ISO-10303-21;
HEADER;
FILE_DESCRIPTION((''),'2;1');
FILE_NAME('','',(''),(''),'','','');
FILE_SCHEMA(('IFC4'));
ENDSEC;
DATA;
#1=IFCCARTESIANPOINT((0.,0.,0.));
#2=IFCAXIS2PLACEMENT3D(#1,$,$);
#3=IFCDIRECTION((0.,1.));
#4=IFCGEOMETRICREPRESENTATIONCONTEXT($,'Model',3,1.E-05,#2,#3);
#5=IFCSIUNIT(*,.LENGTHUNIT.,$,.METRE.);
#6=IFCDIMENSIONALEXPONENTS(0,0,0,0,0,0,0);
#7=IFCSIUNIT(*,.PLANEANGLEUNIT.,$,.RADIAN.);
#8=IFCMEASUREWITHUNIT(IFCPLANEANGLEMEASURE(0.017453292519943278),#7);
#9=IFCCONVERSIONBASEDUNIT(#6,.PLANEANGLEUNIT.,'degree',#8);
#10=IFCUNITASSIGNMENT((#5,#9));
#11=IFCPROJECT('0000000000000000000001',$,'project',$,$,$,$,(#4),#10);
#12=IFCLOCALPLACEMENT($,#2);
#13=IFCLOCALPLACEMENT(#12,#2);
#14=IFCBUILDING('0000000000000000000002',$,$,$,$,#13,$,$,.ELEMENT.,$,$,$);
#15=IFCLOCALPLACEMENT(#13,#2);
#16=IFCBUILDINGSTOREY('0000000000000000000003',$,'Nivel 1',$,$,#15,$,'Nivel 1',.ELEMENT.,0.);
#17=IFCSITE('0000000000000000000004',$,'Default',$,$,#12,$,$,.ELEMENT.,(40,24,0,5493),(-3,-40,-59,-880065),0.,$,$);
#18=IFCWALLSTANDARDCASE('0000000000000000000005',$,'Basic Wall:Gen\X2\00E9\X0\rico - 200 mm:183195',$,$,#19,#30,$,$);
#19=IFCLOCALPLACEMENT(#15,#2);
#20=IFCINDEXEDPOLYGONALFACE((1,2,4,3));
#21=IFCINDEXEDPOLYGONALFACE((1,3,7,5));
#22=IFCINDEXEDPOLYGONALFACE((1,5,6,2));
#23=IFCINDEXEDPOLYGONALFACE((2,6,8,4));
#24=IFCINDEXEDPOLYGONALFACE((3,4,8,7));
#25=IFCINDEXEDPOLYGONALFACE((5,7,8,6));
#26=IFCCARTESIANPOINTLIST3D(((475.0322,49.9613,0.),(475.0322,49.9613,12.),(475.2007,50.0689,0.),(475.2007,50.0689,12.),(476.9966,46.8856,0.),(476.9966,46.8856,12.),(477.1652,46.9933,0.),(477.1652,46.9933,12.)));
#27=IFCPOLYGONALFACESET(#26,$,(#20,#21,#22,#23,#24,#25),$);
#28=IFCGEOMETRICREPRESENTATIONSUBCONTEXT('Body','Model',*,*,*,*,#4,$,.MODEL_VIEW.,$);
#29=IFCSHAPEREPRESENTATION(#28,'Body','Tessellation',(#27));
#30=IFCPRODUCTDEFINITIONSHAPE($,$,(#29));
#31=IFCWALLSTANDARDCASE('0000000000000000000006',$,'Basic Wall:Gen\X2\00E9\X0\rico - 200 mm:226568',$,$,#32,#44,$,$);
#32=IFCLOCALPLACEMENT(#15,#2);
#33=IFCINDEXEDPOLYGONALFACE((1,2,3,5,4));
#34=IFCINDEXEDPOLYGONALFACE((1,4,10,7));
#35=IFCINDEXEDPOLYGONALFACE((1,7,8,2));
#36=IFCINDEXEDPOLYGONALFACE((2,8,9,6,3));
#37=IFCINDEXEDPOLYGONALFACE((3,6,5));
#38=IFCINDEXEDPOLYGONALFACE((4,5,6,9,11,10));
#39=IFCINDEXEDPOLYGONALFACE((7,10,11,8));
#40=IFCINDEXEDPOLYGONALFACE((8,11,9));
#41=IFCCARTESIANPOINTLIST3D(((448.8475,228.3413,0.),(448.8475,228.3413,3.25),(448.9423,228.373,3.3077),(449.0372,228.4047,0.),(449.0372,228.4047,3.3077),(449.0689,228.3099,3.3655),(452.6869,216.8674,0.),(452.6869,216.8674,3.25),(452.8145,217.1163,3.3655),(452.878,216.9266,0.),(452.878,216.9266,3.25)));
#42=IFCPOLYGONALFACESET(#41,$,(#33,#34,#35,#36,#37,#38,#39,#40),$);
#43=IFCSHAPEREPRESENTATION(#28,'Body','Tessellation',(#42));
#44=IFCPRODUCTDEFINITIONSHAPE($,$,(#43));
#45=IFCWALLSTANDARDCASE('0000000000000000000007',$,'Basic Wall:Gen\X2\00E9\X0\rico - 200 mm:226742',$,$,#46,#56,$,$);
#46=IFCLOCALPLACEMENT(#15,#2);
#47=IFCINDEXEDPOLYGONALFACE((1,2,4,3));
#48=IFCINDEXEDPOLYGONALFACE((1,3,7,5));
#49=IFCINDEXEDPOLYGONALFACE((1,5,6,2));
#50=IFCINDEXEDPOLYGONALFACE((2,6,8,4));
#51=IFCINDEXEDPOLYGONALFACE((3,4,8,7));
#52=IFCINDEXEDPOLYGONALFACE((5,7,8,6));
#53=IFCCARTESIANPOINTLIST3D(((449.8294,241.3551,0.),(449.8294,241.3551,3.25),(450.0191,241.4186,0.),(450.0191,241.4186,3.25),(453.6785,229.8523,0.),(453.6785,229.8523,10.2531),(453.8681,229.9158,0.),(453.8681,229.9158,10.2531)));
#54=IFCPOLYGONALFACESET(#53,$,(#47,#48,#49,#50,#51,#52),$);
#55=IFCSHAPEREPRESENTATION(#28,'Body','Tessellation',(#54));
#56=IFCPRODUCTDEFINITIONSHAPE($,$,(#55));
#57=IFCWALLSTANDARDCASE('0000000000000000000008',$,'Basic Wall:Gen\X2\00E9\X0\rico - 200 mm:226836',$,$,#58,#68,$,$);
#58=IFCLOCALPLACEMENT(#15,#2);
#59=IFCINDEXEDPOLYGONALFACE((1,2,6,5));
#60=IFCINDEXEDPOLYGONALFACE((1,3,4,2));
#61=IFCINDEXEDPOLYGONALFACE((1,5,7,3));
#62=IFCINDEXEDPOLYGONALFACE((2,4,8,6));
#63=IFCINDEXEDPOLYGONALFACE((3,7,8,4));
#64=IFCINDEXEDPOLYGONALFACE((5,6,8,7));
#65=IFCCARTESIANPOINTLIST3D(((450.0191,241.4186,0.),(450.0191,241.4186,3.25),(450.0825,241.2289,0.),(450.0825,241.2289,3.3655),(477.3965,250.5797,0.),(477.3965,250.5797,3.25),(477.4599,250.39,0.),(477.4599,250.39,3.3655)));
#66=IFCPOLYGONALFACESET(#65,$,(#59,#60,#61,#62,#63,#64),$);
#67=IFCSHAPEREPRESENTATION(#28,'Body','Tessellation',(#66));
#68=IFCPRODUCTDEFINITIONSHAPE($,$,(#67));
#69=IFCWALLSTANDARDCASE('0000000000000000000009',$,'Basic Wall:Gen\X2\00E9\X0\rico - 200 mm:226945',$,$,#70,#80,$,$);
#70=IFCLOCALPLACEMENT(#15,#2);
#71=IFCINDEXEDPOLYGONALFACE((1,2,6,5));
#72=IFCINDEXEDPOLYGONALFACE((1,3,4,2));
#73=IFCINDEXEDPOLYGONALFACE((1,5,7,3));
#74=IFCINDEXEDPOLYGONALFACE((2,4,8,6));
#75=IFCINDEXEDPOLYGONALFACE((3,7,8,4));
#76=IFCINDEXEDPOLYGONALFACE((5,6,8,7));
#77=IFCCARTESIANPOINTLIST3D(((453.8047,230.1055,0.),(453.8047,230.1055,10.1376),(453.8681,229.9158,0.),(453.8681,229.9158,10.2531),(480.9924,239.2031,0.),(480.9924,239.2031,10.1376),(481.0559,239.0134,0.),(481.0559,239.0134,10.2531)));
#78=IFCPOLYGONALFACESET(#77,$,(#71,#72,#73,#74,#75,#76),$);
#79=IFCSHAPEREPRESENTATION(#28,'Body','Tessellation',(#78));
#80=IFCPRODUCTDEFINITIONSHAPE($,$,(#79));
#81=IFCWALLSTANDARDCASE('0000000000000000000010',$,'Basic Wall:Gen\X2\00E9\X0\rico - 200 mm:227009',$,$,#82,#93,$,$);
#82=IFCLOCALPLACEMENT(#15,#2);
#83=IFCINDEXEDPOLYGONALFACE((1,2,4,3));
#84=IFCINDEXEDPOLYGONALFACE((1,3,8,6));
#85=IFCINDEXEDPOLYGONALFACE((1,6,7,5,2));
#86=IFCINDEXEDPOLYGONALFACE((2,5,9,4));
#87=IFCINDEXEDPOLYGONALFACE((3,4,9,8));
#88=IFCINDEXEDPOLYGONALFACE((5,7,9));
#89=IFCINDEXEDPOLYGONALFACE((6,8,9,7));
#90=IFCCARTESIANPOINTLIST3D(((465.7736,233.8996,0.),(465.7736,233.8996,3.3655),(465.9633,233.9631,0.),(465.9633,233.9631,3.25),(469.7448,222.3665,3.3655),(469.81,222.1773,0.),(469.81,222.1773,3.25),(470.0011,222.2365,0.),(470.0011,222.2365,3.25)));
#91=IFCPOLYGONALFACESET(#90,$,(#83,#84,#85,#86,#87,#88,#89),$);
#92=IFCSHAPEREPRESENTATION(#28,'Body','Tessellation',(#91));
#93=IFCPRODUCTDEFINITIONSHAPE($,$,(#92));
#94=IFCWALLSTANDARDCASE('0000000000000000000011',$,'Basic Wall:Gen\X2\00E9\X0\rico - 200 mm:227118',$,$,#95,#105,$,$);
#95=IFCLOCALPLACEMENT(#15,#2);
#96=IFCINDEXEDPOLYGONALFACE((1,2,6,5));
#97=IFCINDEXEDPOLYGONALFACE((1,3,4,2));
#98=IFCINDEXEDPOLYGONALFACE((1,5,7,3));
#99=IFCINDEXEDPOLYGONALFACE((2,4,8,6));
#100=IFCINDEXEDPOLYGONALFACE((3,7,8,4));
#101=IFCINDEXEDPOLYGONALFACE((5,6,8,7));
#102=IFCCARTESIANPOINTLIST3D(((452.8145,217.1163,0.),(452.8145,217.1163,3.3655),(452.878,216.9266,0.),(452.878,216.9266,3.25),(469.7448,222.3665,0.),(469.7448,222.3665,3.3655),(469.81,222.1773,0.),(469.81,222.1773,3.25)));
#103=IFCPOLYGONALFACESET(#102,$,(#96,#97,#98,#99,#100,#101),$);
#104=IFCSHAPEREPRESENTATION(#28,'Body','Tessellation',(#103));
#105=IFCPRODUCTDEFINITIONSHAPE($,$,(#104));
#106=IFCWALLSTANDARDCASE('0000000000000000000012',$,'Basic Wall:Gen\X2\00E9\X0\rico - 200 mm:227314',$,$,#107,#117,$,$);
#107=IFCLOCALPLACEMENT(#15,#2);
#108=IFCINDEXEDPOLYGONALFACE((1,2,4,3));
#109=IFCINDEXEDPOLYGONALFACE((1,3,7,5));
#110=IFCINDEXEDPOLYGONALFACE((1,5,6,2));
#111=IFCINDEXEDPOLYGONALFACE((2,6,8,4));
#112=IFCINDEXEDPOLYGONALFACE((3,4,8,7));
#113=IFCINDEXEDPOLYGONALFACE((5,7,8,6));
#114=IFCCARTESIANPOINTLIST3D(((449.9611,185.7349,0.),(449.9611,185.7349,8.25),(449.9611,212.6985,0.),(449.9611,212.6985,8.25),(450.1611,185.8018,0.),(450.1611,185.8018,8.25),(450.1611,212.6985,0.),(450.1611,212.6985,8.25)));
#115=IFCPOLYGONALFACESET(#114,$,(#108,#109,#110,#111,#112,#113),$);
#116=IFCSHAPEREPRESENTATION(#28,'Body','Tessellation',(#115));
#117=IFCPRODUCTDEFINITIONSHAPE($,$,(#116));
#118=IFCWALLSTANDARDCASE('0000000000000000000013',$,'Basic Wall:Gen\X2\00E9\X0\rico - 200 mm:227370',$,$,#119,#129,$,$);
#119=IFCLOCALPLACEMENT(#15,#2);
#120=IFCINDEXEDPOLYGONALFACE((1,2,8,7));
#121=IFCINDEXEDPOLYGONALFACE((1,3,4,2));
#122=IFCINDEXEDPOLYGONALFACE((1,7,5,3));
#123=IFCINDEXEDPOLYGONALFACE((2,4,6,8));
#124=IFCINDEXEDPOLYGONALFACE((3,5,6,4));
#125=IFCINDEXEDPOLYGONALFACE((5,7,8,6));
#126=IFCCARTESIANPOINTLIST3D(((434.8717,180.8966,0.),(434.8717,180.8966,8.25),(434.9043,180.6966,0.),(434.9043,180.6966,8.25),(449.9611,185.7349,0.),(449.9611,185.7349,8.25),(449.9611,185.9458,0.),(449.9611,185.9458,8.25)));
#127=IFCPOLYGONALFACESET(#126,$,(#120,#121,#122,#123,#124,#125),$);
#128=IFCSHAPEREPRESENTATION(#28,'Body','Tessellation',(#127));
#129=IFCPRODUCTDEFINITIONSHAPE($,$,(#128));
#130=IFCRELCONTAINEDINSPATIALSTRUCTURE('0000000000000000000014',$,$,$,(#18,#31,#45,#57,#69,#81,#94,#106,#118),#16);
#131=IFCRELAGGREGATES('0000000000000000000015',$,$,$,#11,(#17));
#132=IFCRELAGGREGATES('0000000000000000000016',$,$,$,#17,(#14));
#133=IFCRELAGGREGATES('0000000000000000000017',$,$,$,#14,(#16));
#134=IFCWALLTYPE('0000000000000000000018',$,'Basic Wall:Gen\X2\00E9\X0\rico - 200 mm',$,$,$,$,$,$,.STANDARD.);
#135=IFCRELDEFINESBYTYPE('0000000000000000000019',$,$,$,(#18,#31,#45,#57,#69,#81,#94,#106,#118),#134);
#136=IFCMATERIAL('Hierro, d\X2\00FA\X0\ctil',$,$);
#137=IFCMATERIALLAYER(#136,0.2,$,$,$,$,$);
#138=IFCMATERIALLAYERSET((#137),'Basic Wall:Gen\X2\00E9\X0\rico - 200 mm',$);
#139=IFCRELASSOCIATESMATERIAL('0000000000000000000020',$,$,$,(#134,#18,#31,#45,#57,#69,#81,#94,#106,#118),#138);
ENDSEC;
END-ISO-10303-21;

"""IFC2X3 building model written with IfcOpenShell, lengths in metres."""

from ifc_helpers import new_model, entity, si_unit, converted_unit, direction, frame, frame_2d, origin, place, context, subcontext, project, spatial, polyline, rectangle, outline, extrude, clip, bounded_halfspace, material, layer, layer_set, layer_usage, type_object, element, save


model = new_model("IFC2X3")

# Units and contexts
model_context = context("Model", 3, precision=1e-05, world=origin(), true_north=direction((0.0, 1.0)))
body_context = subcontext(model_context, "Body", "Model", "MODEL_VIEW")
ifc_project = project(units=[si_unit("LENGTHUNIT", "METRE"), converted_unit("PLANEANGLEUNIT", "degree", entity("IfcPlaneAngleMeasure", 0.017453292519943278), si_unit("PLANEANGLEUNIT", "RADIAN"), dimensions=[0, 0, 0, 0, 0, 0, 0])], contexts=[model_context])

# Site, building, storey
site_placement = place(None, origin())
site = spatial("IfcSite", under=ifc_project, at=site_placement, Name="Default", CompositionType="ELEMENT", RefLatitude=(40, 24, 0, 5493), RefLongitude=(-3, -40, -59, -880065), RefElevation=0.0)
building_placement = place(site_placement, origin())
building = spatial("IfcBuilding", under=site, at=building_placement, CompositionType="ELEMENT")
storey_placement = place(building_placement, origin())
storey = spatial("IfcBuildingStorey", under=building, at=storey_placement, Name="Nivel 1", LongName="Nivel 1", CompositionType="ELEMENT", Elevation=0.0)

# Walls
ifc_material_1 = material(Name="Hierro, dúctil")
ifc_layer_1 = layer(ifc_material_1, 0.2)
ifc_layer_set_1 = layer_set([ifc_layer_1], Name="Basic Wall:Genérico - 200 mm")
wall_type = type_object("IfcWallType", Name="Basic Wall:Genérico - 200 mm", PredefinedType="STANDARD", material=ifc_layer_set_1)
ifc_layer_usage_1 = layer_usage(ifc_layer_set_1, "AXIS2", "NEGATIVE", 0.1)
wall_1_placement = place(storey_placement, frame((477.0809, 46.9394, 0.0), z_axis=(0.0, 0.0, 1.0), x_axis=(-0.538277, 0.842768, 0.0)))
element("IfcWallStandardCase", 1, at=wall_1_placement, inside=storey, type_object=wall_type, material=ifc_layer_usage_1, Name="Basic Wall:Genérico - 200 mm:183195", context=body_context, shape_type="SweptSolid", body=[
    extrude(rectangle(XDim=3.6495, YDim=0.2, at=frame_2d((1.8247, 0.0), x_axis=(-1.0, 0.0))), origin(), (0.0, 0.0, 1.0), 12.0),
])
ifc_layer_usage_2 = layer_usage(ifc_layer_set_1, "AXIS2", "NEGATIVE", 0.1)
wall_2_placement = place(storey_placement, frame((452.7832, 216.8949, 0.0), z_axis=(0.0, 0.0, 1.0), x_axis=(-0.317327, 0.948316, 0.0)))
element("IfcWallStandardCase", 2, at=wall_2_placement, inside=storey, type_object=wall_type, material=ifc_layer_usage_2, Name="Basic Wall:Genérico - 200 mm:226568", context=body_context, shape_type="Clipping", body=[
    clip(clip(clip(extrude(outline(polyline([(12.1037, -0.1), (12.1037, 0.1), (0.0044, 0.1), (0.0, -0.1), (0.2, -0.1), (12.1037, -0.1)])), origin(), (0.0, 0.0, 1.0), 3.3655), bounded_halfspace(frame((12.0037, -0.1, 3.3655), z_axis=(0.5, 0.0, 0.866025), x_axis=(0.0, 1.0, 0.0)), False, frame((12.0037, -0.1, 3.3655)), polyline([(0.0, 0.0), (0.1, 0.0), (0.1, 0.1), (0.0, 0.0)]))), bounded_halfspace(frame((0.2, -0.1, 3.3655), z_axis=(0.0, 0.5, 0.866025), x_axis=(-1.0, 0.0, 0.0)), False, frame((0.2, -0.1, 3.3655)), polyline([(0.0, 0.0), (11.8036, 0.0), (11.9036, 0.1), (11.9036, 0.2), (-0.1956, 0.2), (0.0, 0.0)]))), bounded_halfspace(frame((0.0, -0.1, 3.25), z_axis=(-0.499877, 0.011104, 0.866025), x_axis=(-0.022207, -0.999753, 0.0)), False, frame((0.0, -0.1, 3.25)), polyline([(0.0, 0.0), (0.2, 0.0), (0.0044, 0.2), (0.0, 0.0)]))),
])
ifc_layer_usage_3 = layer_usage(ifc_layer_set_1, "AXIS2", "NEGATIVE", 0.1)
wall_3_placement = place(storey_placement, frame((453.7733, 229.8841, 0.0), z_axis=(0.0, 0.0, 1.0), x_axis=(-0.317327, 0.948316, 0.0)))
element("IfcWallStandardCase", 3, at=wall_3_placement, inside=storey, type_object=wall_type, material=ifc_layer_usage_3, Name="Basic Wall:Genérico - 200 mm:226742", context=body_context, shape_type="Clipping", body=[
    clip(extrude(rectangle(XDim=12.1297, YDim=0.2, at=frame_2d((6.0648, 0.0), x_axis=(-1.0, 0.0))), origin(), (0.0, 0.0, 1.0), 10.2531), bounded_halfspace(frame((0.0, -0.1, 10.2531), z_axis=(0.5, 0.0, 0.866025), x_axis=(0.0, 1.0, 0.0)), False, frame((0.0, -0.1, 10.2531)), polyline([(0.0, 0.0), (0.2, 0.0), (11.9297, 0.0), (12.1297, 0.0), (12.1297, 0.2), (0.0, 0.2), (0.0, 0.0)]))),
])
ifc_layer_usage_4 = layer_usage(ifc_layer_set_1, "AXIS2", "NEGATIVE", 0.1)
wall_4_placement = place(storey_placement, frame((450.0508, 241.3238, 0.0), z_axis=(0.0, 0.0, 1.0), x_axis=(0.948316, 0.317327, 0.0)))
element("IfcWallStandardCase", 4, at=wall_4_placement, inside=storey, type_object=wall_type, material=ifc_layer_usage_4, Name="Basic Wall:Genérico - 200 mm:226836", context=body_context, shape_type="Clipping", body=[
    clip(extrude(rectangle(XDim=28.8695, YDim=0.2, at=frame_2d((14.4347, 0.0), x_axis=(-1.0, 0.0))), origin(), (0.0, 0.0, 1.0), 3.3655), bounded_halfspace(frame((0.0, -0.1, 3.3655), z_axis=(0.0, 0.5, 0.866025), x_axis=(-1.0, 0.0, 0.0)), False, frame((0.0, -0.1, 3.3655)), polyline([(0.0, 0.0), (28.6695, 0.0), (28.8695, 0.0), (28.8695, 0.2), (0.0, 0.2), (0.0, 0.0)]))),
])
ifc_layer_usage_5 = layer_usage(ifc_layer_set_1, "AXIS2", "NEGATIVE", 0.1)
wall_5_placement = place(storey_placement, frame((481.0241, 239.1083, 0.0), z_axis=(0.0, 0.0, 1.0), x_axis=(-0.948316, -0.317327, 0.0)))
element("IfcWallStandardCase", 5, at=wall_5_placement, inside=storey, type_object=wall_type, material=ifc_layer_usage_5, Name="Basic Wall:Genérico - 200 mm:226945", context=body_context, shape_type="Clipping", body=[
    clip(extrude(rectangle(XDim=28.6695, YDim=0.2, at=frame_2d((14.3347, 0.0), x_axis=(-1.0, 0.0))), origin(), (0.0, 0.0, 1.0), 10.2531), bounded_halfspace(frame((0.0, -0.1, 10.1376), z_axis=(0.0, -0.5, 0.866025), x_axis=(1.0, 0.0, 0.0)), False, frame((0.0, -0.1, 10.1376)), polyline([(0.0, 0.0), (28.6695, 0.0), (28.6695, 0.2), (0.0, 0.2), (0.0, 0.0)]))),
])
ifc_layer_usage_6 = layer_usage(ifc_layer_set_1, "AXIS2", "NEGATIVE", 0.1)
wall_6_placement = place(storey_placement, frame((465.8682, 233.9322, 0.0), z_axis=(0.0, 0.0, 1.0), x_axis=(0.325568, -0.945519, 0.0)))
element("IfcWallStandardCase", 6, at=wall_6_placement, inside=storey, type_object=wall_type, material=ifc_layer_usage_6, Name="Basic Wall:Genérico - 200 mm:227009", context=body_context, shape_type="Clipping", body=[
    clip(clip(extrude(outline(polyline([(12.3978, -0.1), (12.404, 0.1), (0.0017, 0.1), (0.0, -0.1), (12.1977, -0.1), (12.3978, -0.1)])), origin(), (0.0, 0.0, 1.0), 3.3655), bounded_halfspace(frame((0.0, -0.1, 3.3655), z_axis=(0.0, 0.5, 0.866025), x_axis=(-1.0, 0.0, 0.0)), False, frame((0.0, -0.1, 3.3655)), polyline([(0.0, 0.0), (12.1977, 0.0), (12.404, 0.2), (0.0017, 0.2), (0.0, 0.0)]))), bounded_halfspace(frame((12.1977, -0.1, 3.3655), z_axis=(0.499761, -0.015453, 0.866025), x_axis=(0.030907, 0.999522, 0.0)), False, frame((12.1977, -0.1, 3.3655)), polyline([(0.0, 0.0), (0.2001, 0.0), (0.2063, 0.2), (0.0, 0.0)]))),
])
ifc_layer_usage_7 = layer_usage(ifc_layer_set_1, "AXIS2", "NEGATIVE", 0.1)
wall_7_placement = place(storey_placement, frame((469.7803, 222.2728, 0.0), z_axis=(0.0, 0.0, 1.0), x_axis=(-0.955129, -0.29619, 0.0)))
element("IfcWallStandardCase", 7, at=wall_7_placement, inside=storey, type_object=wall_type, material=ifc_layer_usage_7, Name="Basic Wall:Genérico - 200 mm:227118", context=body_context, shape_type="Clipping", body=[
    clip(extrude(outline(polyline([(17.7318, -0.1), (17.7274, 0.1), (0.0, 0.1), (0.0062, -0.1), (17.7318, -0.1)])), origin(), (0.0, 0.0, 1.0), 3.3655), bounded_halfspace(frame((0.0062, -0.1, 3.3655), z_axis=(0.0, 0.5, 0.866025), x_axis=(-1.0, 0.0, 0.0)), False, frame((0.0062, -0.1, 3.3655)), polyline([(0.0, 0.0), (17.7257, 0.0), (17.7212, 0.2), (-0.0062, 0.2), (0.0, 0.0)]))),
])
ifc_layer_usage_8 = layer_usage(ifc_layer_set_1, "AXIS2", "NEGATIVE", 0.1)
wall_8_placement = place(storey_placement, frame((450.0611, 212.6985, 0.0), z_axis=(0.0, 0.0, 1.0), x_axis=(0.0, -1.0, 0.0)))
element("IfcWallStandardCase", 8, at=wall_8_placement, inside=storey, type_object=wall_type, material=ifc_layer_usage_8, Name="Basic Wall:Genérico - 200 mm:227314", context=body_context, shape_type="Clipping", body=[
    clip(extrude(outline(polyline([(26.9636, -0.1), (26.8967, 0.1), (0.0, 0.1), (0.0, -0.1), (26.7527, -0.1), (26.9636, -0.1)])), origin(), (0.0, 0.0, 1.0), 8.25), bounded_halfspace(frame((0.0, -0.1, 8.25), z_axis=(0.0, 0.0, 1.0), x_axis=(0.0, 1.0, 0.0)), False, frame((0.0, -0.1, 8.25)), polyline([(0.0, 0.0), (26.7527, 0.0), (26.9636, 0.0), (26.8967, 0.2), (0.0, 0.2), (0.0, 0.0)]))),
])
ifc_layer_usage_9 = layer_usage(ifc_layer_set_1, "AXIS2", "NEGATIVE", 0.1)
wall_9_placement = place(storey_placement, frame((449.9928, 185.8509, 0.0), z_axis=(0.0, 0.0, 1.0), x_axis=(-0.948316, -0.317327, 0.0)))
element("IfcWallStandardCase", 9, at=wall_9_placement, inside=storey, type_object=wall_type, material=ifc_layer_usage_9, Name="Basic Wall:Genérico - 200 mm:227370", context=body_context, shape_type="Clipping", body=[
    clip(extrude(outline(polyline([(15.9117, -0.1), (15.9443, 0.1), (0.0669, 0.1), (0.0, -0.1), (15.9117, -0.1)])), origin(), (0.0, 0.0, 1.0), 8.25), bounded_halfspace(frame((0.0, -0.1, 8.25), z_axis=(0.0, 0.0, 1.0), x_axis=(-0.948316, 0.317327, 0.0)), False, frame((0.0, -0.1, 8.25)), polyline([(0.0, 0.0), (15.9117, 0.0), (15.9443, 0.2), (0.0669, 0.2), (0.0, 0.0)]))),
])

save(model, "model.ifc")
